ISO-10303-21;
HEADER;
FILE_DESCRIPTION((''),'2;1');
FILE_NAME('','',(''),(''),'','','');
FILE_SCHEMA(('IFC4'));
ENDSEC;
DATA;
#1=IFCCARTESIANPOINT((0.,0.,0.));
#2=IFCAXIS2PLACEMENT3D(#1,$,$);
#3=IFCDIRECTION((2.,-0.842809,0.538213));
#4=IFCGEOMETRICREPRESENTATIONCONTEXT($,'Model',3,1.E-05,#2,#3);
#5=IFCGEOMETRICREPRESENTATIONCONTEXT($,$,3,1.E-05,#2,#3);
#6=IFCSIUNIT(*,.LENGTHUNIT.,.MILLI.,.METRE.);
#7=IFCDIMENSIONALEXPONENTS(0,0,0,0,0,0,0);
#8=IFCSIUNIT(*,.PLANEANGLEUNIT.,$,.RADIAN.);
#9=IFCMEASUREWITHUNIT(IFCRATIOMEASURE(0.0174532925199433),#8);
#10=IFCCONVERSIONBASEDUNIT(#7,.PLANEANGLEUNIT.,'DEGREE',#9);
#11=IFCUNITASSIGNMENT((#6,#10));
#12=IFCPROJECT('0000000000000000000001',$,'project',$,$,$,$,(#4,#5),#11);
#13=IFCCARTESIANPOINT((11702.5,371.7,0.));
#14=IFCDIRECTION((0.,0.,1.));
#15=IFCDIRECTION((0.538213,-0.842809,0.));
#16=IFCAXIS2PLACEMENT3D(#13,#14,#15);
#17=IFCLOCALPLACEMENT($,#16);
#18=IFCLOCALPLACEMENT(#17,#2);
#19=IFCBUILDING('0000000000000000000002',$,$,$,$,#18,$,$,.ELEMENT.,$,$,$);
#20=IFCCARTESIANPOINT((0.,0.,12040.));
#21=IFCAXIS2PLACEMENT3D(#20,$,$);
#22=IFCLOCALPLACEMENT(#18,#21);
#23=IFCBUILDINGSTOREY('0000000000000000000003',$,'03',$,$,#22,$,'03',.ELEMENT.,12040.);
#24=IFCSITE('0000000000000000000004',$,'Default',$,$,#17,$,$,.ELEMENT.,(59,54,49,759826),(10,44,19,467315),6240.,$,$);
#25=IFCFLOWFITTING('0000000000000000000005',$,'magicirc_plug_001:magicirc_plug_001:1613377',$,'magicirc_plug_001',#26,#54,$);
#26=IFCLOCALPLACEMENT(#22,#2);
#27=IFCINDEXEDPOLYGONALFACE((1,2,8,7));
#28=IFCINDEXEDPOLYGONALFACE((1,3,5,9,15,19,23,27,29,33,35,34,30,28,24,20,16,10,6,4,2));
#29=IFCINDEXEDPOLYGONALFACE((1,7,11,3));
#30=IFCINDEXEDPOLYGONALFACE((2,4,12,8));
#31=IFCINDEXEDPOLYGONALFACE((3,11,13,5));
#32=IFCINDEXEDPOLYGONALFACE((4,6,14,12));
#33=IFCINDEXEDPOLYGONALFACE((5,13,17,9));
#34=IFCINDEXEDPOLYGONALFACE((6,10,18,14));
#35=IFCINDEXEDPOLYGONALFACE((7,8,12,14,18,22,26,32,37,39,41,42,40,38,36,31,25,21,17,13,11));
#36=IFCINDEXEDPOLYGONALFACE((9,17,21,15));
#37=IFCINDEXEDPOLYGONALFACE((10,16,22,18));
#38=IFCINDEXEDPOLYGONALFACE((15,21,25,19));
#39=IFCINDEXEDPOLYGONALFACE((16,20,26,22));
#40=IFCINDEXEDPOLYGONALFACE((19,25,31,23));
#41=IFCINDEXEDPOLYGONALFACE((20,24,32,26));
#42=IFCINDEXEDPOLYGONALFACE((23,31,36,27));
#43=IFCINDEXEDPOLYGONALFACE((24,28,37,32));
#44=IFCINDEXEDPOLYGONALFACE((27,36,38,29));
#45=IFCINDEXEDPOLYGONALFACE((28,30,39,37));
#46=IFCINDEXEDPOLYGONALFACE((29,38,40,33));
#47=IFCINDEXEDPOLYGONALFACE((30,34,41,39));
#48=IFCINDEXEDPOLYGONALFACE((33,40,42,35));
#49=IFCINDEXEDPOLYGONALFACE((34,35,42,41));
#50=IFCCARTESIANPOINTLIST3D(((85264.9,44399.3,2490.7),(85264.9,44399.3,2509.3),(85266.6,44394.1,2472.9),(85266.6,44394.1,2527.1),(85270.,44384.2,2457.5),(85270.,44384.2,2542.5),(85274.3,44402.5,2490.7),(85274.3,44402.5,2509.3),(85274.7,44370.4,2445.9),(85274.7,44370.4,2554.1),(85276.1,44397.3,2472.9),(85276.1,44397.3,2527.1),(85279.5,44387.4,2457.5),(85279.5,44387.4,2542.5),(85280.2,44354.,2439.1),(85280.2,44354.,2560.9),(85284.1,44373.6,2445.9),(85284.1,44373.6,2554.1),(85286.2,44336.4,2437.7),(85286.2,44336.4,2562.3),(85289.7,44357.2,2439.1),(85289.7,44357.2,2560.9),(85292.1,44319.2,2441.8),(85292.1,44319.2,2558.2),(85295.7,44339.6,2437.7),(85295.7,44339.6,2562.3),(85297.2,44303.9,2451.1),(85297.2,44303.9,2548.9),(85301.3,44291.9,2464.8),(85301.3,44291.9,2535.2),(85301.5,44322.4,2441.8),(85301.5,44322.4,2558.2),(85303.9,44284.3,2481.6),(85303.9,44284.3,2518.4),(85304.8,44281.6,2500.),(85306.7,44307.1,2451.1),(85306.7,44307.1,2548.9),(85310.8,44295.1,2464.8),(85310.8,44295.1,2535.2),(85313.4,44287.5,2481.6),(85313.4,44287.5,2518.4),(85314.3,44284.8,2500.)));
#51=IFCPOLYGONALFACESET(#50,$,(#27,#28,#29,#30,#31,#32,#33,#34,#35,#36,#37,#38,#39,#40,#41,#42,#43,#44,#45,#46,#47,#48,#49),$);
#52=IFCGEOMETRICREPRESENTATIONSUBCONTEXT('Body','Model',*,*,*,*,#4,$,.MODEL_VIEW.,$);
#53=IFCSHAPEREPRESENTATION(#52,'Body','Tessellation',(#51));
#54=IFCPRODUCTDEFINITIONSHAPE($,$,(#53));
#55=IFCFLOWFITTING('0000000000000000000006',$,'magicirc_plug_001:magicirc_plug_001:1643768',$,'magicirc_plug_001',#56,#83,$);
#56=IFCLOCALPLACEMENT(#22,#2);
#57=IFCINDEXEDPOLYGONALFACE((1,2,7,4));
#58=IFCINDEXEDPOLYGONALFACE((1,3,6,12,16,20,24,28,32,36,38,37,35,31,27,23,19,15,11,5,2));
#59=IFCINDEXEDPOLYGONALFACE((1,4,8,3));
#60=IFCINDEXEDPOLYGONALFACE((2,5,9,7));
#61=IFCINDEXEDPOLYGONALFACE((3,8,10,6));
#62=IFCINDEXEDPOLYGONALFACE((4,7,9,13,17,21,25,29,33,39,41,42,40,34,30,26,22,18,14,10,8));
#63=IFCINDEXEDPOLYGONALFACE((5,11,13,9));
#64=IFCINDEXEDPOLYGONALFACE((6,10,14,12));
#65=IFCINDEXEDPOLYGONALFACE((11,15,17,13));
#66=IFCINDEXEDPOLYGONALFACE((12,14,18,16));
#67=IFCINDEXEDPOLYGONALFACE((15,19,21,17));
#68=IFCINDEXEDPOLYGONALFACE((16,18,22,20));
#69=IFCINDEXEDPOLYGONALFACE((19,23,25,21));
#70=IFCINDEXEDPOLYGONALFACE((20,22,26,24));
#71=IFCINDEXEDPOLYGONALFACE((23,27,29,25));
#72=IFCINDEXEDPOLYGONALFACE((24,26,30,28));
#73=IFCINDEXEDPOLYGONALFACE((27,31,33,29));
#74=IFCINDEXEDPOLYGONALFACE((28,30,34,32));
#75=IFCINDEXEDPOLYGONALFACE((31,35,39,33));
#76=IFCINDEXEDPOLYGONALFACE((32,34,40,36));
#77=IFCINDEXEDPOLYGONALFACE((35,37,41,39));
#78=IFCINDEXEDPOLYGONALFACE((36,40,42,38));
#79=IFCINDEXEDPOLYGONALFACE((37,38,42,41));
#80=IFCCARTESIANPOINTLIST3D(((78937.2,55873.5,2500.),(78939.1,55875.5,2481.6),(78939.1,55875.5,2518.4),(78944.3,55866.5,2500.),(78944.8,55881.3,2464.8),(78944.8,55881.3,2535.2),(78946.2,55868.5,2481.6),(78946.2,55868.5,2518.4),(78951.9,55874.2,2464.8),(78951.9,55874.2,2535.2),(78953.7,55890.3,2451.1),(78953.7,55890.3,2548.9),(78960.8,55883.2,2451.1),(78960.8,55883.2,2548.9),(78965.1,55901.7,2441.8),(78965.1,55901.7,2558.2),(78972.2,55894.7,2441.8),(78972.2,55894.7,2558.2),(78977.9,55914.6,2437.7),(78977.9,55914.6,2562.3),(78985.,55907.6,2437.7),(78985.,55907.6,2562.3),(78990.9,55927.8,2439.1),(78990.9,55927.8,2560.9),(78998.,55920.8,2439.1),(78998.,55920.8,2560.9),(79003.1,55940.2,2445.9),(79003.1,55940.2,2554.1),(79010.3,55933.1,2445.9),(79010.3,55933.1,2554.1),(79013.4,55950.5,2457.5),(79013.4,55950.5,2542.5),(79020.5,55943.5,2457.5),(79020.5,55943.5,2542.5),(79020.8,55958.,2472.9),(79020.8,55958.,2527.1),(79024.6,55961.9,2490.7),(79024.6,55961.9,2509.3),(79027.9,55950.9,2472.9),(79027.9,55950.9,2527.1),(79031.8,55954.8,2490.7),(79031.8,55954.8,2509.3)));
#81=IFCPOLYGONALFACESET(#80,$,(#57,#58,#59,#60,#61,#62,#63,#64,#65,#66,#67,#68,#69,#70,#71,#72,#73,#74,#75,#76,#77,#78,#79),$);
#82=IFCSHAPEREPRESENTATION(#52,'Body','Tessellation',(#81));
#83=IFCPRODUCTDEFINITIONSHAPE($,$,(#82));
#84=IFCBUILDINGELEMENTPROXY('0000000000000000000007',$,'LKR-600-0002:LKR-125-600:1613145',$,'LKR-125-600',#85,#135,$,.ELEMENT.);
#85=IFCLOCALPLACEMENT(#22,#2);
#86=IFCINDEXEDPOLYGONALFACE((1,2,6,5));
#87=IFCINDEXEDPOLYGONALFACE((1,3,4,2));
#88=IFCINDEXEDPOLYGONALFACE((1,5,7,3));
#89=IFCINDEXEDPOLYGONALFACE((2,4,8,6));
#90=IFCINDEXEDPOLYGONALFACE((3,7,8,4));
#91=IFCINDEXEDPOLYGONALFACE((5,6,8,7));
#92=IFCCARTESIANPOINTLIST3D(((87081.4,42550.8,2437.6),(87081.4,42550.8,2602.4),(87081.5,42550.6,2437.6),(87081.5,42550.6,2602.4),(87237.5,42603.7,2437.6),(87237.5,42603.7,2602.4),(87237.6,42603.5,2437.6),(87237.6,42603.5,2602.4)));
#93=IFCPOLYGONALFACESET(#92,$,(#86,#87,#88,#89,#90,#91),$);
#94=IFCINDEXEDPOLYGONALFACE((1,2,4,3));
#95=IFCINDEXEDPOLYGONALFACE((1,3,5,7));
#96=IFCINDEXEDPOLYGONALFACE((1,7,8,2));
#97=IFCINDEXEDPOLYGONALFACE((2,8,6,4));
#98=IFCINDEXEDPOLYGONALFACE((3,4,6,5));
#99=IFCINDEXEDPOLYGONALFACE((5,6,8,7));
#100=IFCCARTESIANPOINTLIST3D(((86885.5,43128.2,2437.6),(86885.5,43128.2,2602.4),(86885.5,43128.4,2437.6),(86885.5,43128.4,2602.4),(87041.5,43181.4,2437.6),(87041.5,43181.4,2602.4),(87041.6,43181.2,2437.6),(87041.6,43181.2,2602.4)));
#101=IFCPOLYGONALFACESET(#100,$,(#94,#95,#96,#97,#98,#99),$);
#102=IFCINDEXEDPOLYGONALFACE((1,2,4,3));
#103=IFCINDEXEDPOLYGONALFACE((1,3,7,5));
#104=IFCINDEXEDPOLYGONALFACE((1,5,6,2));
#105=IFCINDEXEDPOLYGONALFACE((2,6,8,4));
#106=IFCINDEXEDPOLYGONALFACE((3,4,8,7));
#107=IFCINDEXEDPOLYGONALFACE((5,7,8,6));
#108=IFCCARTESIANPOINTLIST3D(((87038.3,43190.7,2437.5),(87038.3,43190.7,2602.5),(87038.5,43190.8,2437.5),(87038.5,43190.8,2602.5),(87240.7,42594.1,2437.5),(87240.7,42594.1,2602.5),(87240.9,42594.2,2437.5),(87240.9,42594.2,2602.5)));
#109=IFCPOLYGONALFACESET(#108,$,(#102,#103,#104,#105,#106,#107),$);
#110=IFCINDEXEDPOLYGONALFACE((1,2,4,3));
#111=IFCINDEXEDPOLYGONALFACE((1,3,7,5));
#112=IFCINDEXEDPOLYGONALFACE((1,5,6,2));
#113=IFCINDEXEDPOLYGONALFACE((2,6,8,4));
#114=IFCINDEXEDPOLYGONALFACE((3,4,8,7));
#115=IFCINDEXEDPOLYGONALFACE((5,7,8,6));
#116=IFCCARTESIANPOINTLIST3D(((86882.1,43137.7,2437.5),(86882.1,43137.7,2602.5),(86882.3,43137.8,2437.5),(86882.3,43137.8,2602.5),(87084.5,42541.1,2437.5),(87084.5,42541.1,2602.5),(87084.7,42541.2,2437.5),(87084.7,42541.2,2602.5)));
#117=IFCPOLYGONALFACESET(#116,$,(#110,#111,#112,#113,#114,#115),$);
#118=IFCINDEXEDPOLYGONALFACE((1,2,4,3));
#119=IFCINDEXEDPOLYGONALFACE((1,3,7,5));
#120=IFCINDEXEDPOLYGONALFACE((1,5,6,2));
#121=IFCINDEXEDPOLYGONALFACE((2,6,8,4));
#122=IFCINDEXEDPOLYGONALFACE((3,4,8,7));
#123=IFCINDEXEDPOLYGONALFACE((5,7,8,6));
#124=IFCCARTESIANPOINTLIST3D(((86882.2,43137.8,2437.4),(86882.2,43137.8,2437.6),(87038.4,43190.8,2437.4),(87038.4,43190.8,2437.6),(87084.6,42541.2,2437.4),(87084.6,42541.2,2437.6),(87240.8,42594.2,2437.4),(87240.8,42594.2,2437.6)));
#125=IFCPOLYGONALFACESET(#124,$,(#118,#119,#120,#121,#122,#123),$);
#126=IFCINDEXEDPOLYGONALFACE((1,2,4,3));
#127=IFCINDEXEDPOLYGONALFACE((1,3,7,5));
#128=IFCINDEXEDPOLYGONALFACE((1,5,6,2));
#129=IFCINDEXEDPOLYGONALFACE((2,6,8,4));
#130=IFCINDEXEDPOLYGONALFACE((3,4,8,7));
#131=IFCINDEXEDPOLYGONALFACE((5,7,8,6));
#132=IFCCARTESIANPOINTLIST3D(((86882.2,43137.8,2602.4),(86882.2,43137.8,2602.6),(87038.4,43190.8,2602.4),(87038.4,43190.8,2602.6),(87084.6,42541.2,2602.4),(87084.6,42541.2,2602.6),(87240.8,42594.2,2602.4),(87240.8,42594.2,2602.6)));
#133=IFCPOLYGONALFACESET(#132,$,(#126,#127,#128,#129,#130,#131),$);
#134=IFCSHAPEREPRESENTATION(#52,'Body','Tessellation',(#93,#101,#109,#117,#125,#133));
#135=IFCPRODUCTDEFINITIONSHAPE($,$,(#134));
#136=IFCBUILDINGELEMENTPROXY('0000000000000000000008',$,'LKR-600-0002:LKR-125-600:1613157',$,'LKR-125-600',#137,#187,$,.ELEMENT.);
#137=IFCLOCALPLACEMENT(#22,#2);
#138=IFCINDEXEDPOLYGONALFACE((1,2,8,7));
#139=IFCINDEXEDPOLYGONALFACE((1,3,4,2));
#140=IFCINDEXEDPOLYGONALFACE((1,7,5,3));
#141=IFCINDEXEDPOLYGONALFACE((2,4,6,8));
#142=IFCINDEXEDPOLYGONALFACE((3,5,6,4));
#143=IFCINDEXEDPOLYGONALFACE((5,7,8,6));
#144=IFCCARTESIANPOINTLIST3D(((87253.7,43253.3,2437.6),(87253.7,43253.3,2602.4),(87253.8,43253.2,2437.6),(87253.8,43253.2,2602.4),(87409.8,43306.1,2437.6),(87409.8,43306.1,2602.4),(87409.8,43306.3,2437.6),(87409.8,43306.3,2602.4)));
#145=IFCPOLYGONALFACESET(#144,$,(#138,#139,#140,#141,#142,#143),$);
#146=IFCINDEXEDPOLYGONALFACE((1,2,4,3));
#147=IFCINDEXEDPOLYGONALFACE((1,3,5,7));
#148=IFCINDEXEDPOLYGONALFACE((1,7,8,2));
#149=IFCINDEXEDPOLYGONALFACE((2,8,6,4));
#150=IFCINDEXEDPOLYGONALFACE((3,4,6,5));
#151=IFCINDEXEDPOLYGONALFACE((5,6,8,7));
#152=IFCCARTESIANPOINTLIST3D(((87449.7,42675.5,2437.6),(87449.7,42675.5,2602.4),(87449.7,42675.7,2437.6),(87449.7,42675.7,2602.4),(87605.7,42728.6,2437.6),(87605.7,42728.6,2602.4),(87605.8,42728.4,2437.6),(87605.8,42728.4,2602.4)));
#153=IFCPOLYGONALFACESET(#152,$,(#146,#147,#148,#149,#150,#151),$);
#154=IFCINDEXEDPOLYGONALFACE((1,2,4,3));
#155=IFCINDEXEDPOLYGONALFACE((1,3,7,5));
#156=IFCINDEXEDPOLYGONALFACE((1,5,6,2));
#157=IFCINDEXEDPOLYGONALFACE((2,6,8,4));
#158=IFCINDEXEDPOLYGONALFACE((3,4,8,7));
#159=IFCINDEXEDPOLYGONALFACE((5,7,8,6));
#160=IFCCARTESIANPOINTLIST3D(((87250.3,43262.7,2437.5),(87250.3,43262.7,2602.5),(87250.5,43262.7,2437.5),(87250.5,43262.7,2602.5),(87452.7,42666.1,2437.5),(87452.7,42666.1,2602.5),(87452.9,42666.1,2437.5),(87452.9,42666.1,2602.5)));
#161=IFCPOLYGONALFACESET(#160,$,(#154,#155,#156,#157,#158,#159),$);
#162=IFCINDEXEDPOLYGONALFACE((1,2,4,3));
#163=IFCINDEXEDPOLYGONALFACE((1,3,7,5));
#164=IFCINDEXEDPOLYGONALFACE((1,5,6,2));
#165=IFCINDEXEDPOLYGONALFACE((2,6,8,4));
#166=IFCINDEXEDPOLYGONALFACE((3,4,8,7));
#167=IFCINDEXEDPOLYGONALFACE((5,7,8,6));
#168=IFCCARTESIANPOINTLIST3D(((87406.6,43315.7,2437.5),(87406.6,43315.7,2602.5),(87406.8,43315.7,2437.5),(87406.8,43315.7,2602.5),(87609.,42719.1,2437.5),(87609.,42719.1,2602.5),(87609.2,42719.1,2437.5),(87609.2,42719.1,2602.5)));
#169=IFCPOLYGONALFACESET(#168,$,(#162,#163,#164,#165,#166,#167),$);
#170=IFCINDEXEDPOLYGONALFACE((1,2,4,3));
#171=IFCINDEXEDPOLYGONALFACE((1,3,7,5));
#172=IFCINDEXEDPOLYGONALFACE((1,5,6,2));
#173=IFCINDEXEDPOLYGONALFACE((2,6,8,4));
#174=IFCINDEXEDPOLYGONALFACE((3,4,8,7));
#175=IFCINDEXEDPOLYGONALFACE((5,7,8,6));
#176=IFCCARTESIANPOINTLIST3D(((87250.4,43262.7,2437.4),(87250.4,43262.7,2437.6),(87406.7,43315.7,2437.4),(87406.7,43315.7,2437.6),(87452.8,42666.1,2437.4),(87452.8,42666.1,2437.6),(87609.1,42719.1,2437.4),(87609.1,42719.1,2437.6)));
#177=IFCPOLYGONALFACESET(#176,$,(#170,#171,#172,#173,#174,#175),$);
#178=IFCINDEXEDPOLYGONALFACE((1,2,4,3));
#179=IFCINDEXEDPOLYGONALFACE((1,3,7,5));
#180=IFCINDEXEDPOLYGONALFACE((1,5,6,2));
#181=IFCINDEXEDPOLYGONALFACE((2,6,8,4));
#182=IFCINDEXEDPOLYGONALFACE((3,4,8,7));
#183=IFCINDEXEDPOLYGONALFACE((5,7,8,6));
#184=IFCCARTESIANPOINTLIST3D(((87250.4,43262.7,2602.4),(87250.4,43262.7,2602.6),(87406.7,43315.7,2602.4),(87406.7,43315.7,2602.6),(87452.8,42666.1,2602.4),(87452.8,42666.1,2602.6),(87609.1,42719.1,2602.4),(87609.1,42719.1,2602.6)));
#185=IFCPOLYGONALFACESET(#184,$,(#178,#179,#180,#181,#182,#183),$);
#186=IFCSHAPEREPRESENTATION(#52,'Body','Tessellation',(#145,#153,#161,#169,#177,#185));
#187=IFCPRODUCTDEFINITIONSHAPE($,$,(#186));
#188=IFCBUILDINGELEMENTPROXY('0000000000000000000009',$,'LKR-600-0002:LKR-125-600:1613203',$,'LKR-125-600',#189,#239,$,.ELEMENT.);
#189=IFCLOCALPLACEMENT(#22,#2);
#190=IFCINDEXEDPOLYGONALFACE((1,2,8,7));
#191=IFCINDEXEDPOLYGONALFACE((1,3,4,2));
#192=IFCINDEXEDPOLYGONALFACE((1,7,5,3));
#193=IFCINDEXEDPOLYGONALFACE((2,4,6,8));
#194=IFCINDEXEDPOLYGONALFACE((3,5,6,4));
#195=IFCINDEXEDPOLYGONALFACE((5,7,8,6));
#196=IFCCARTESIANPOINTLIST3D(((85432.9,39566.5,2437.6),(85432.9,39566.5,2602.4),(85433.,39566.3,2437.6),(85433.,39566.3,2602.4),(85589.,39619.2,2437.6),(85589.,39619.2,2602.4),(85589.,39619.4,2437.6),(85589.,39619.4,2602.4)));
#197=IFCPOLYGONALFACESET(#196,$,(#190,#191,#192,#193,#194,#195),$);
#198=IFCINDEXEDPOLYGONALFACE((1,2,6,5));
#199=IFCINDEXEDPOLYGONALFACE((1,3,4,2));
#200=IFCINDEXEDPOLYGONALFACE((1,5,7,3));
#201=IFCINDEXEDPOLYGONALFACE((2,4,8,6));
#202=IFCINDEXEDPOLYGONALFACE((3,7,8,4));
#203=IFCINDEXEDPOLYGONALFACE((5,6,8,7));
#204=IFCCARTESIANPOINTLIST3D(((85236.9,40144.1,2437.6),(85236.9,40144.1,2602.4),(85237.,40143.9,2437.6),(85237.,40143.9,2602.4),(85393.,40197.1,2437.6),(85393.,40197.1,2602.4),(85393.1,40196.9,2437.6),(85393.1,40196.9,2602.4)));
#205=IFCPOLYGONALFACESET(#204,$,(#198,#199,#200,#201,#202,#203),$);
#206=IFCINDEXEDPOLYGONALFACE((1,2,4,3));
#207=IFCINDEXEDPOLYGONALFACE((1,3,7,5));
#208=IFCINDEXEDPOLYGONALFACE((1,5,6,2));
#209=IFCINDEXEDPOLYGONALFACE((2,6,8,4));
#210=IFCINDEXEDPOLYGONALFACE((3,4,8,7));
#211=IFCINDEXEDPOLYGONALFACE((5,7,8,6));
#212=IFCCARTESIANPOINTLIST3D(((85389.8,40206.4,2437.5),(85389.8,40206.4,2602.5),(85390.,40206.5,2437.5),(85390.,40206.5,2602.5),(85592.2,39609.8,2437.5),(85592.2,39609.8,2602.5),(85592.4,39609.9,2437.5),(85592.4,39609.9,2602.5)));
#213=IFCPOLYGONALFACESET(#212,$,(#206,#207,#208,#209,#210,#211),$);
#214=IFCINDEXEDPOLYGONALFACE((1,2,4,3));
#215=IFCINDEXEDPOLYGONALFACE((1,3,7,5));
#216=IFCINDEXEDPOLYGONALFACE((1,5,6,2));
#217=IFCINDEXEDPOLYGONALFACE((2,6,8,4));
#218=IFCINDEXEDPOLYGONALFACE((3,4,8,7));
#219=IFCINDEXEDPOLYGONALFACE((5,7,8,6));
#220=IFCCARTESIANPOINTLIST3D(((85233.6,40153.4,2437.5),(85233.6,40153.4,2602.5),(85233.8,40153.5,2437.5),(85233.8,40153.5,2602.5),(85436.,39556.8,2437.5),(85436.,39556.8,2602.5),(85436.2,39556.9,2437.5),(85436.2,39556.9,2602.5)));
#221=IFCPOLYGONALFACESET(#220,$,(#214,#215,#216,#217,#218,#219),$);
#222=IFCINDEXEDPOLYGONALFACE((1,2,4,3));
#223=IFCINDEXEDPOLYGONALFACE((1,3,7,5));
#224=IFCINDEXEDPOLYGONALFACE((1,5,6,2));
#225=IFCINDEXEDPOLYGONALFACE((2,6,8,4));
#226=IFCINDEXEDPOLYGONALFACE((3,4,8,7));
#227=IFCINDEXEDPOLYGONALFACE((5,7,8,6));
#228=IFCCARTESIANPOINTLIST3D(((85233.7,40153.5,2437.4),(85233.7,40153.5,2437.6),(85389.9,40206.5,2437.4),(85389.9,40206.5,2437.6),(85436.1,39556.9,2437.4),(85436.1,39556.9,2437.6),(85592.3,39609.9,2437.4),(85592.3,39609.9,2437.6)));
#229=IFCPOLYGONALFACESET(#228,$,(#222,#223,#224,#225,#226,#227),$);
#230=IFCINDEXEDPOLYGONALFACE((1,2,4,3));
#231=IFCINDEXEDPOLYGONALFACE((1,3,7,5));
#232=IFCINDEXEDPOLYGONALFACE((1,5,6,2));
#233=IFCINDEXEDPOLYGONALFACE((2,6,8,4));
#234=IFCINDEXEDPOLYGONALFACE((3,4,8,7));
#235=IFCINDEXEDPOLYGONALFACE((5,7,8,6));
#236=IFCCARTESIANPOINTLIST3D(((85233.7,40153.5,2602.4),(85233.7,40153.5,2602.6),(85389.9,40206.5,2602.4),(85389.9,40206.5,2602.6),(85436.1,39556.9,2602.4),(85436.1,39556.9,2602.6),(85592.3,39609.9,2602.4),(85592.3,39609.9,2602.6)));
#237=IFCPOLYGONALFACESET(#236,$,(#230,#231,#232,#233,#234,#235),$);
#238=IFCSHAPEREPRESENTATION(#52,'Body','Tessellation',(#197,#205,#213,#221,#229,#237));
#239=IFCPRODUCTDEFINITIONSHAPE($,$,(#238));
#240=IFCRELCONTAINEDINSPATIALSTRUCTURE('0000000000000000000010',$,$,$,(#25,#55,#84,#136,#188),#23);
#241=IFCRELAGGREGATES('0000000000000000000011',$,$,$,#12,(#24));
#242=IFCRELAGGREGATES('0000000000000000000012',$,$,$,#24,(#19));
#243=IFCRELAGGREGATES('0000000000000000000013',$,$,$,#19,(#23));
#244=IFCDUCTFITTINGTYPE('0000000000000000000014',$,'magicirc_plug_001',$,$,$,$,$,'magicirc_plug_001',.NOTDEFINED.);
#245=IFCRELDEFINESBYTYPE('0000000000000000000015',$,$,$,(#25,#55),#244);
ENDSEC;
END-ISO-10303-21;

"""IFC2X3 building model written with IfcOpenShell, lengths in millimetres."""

from ifc_helpers import new_model, entity, si_unit, converted_unit, direction, frame, frame_2d, origin, place, context, subcontext, project, spatial, rectangle, circle, extrude, source, transform, mapped, type_object, type_shapes, element, save


model = new_model("IFC2X3")

# Units and contexts
model_context = context("Model", 3, precision=1e-05, world=origin(), true_north=direction((2.0, -0.842809, 0.538213)))
context_of_model = context(None, 3, precision=1e-05, world=origin(), true_north=direction((2.0, -0.842809, 0.538213)))
body_context = subcontext(model_context, "Body", "Model", "MODEL_VIEW")
ifc_project = project(units=[si_unit("LENGTHUNIT", "METRE", prefix="MILLI"), converted_unit("PLANEANGLEUNIT", "DEGREE", entity("IfcRatioMeasure", 0.0174532925199433), si_unit("PLANEANGLEUNIT", "RADIAN"), dimensions=[0, 0, 0, 0, 0, 0, 0])], contexts=[model_context, context_of_model])

# Site, building, storey
site_placement = place(None, frame((11702.5, 371.7, 0.0), z_axis=(0.0, 0.0, 1.0), x_axis=(0.538213, -0.842809, 0.0)))
site = spatial("IfcSite", under=ifc_project, at=site_placement, Name="Default", CompositionType="ELEMENT", RefLatitude=(59, 54, 49, 759826), RefLongitude=(10, 44, 19, 467315), RefElevation=6240.0)
building_placement = place(site_placement, origin())
building = spatial("IfcBuilding", under=site, at=building_placement, CompositionType="ELEMENT")
storey_placement = place(building_placement, frame((0.0, 0.0, 12040.0)))
storey = spatial("IfcBuildingStorey", under=building, at=storey_placement, Name="03", LongName="03", CompositionType="ELEMENT", Elevation=12040.0)

# Flow fittings
duct_fitting_type_1 = type_object("IfcDuctFittingType", Name="magicirc_plug_001", ElementType="magicirc_plug_001", PredefinedType="NOTDEFINED")
shared_shape_1 = source(origin(), body_context, "Body", "SweptSolid", [
    extrude(circle(Radius=62.5, at=frame_2d((0.0, 0.0), x_axis=(1.0, 0.0))), frame((0.0, 0.0, 0.0), z_axis=(1.0, 0.0, 0.0), x_axis=(0.0, 1.0, 0.0)), (0.0, 0.0, 1.0), 10.0),
])
type_shapes(duct_fitting_type_1, [shared_shape_1])
for number, where, z_axis, x_axis, name in (
    (1, (85294.2, 44344.0, 2500.0), (0.0, 0.0, 1.0), (-0.946986, -0.321274, 0.0), "magicirc_plug_001:magicirc_plug_001:1613377"),
    (2, (78988.3, 55910.9, 2500.0), (0.0, 0.0, 1.0), (-0.710528, 0.703669, 0.0), "magicirc_plug_001:magicirc_plug_001:1643768"),
):
    element("IfcFlowFitting", number, at=place(storey_placement, frame(where, z_axis=z_axis, x_axis=x_axis)), inside=storey, type_object=duct_fitting_type_1, Name=name, ObjectType="magicirc_plug_001", context=body_context, shape_type="MappedRepresentation", body=[
        mapped(shared_shape_1, transform((0.0, 0.0, 0.0), scale=1.0)),
    ])

# Building element proxies
shared_shape_2 = source(origin(), body_context, "Body", "SweptSolid", [
    extrude(rectangle(XDim=0.2, YDim=164.8, at=frame_2d((0.0, 0.0), x_axis=(1.0, 0.0))), frame((305.0, 0.0, -82.4)), (0.0, 0.0, 1.0), 164.8),
    extrude(rectangle(XDim=0.2, YDim=164.8, at=frame_2d((0.0, 0.0), x_axis=(1.0, 0.0))), frame((-305.0, 0.0, -82.4)), (0.0, 0.0, 1.0), 164.8),
    extrude(rectangle(XDim=0.2, YDim=630.0, at=frame_2d((0.0, 0.0), x_axis=(1.0, 0.0))), frame((0.0, 82.5, -82.5), z_axis=(0.0, 0.0, 1.0), x_axis=(0.0, 1.0, 0.0)), (0.0, 0.0, 1.0), 165.0),
    extrude(rectangle(XDim=0.2, YDim=630.0, at=frame_2d((0.0, 0.0), x_axis=(1.0, 0.0))), frame((0.0, -82.5, -82.5), z_axis=(0.0, 0.0, 1.0), x_axis=(0.0, 1.0, 0.0)), (0.0, 0.0, 1.0), 165.0),
    extrude(rectangle(XDim=165.0, YDim=630.0, at=frame_2d((0.0, 0.0), x_axis=(1.0, 0.0))), frame((0.0, 0.0, -82.6), z_axis=(0.0, 0.0, 1.0), x_axis=(0.0, -1.0, 0.0)), (0.0, 0.0, 1.0), 0.2),
    extrude(rectangle(XDim=165.0, YDim=630.0, at=frame_2d((0.0, 0.0), x_axis=(1.0, 0.0))), frame((0.0, 0.0, 82.4), z_axis=(0.0, 0.0, 1.0), x_axis=(0.0, -1.0, 0.0)), (0.0, 0.0, 1.0), 0.2),
])
for number, where, z_axis, x_axis, name in (
    (3, (87061.5, 42866.0, 2520.0), (0.0, 0.0, 1.0), (0.321274, -0.946986, 0.0), "LKR-600-0002:LKR-125-600:1613145"),
    (4, (87429.8, 42990.9, 2520.0), (0.0, 0.0, 1.0), (-0.321274, 0.946986, 0.0), "LKR-600-0002:LKR-125-600:1613157"),
    (5, (85413.0, 39881.7, 2520.0), (0.0, 0.0, 1.0), (0.321274, -0.946986, 0.0), "LKR-600-0002:LKR-125-600:1613203"),
):
    element("IfcBuildingElementProxy", number, at=place(storey_placement, frame(where, z_axis=z_axis, x_axis=x_axis)), inside=storey, Name=name, ObjectType="LKR-125-600", CompositionType="ELEMENT", context=body_context, shape_type="MappedRepresentation", body=[
        mapped(shared_shape_2, transform((0.0, 0.0, 0.0), scale=1.0)),
    ])

save(model, "model.ifc")
